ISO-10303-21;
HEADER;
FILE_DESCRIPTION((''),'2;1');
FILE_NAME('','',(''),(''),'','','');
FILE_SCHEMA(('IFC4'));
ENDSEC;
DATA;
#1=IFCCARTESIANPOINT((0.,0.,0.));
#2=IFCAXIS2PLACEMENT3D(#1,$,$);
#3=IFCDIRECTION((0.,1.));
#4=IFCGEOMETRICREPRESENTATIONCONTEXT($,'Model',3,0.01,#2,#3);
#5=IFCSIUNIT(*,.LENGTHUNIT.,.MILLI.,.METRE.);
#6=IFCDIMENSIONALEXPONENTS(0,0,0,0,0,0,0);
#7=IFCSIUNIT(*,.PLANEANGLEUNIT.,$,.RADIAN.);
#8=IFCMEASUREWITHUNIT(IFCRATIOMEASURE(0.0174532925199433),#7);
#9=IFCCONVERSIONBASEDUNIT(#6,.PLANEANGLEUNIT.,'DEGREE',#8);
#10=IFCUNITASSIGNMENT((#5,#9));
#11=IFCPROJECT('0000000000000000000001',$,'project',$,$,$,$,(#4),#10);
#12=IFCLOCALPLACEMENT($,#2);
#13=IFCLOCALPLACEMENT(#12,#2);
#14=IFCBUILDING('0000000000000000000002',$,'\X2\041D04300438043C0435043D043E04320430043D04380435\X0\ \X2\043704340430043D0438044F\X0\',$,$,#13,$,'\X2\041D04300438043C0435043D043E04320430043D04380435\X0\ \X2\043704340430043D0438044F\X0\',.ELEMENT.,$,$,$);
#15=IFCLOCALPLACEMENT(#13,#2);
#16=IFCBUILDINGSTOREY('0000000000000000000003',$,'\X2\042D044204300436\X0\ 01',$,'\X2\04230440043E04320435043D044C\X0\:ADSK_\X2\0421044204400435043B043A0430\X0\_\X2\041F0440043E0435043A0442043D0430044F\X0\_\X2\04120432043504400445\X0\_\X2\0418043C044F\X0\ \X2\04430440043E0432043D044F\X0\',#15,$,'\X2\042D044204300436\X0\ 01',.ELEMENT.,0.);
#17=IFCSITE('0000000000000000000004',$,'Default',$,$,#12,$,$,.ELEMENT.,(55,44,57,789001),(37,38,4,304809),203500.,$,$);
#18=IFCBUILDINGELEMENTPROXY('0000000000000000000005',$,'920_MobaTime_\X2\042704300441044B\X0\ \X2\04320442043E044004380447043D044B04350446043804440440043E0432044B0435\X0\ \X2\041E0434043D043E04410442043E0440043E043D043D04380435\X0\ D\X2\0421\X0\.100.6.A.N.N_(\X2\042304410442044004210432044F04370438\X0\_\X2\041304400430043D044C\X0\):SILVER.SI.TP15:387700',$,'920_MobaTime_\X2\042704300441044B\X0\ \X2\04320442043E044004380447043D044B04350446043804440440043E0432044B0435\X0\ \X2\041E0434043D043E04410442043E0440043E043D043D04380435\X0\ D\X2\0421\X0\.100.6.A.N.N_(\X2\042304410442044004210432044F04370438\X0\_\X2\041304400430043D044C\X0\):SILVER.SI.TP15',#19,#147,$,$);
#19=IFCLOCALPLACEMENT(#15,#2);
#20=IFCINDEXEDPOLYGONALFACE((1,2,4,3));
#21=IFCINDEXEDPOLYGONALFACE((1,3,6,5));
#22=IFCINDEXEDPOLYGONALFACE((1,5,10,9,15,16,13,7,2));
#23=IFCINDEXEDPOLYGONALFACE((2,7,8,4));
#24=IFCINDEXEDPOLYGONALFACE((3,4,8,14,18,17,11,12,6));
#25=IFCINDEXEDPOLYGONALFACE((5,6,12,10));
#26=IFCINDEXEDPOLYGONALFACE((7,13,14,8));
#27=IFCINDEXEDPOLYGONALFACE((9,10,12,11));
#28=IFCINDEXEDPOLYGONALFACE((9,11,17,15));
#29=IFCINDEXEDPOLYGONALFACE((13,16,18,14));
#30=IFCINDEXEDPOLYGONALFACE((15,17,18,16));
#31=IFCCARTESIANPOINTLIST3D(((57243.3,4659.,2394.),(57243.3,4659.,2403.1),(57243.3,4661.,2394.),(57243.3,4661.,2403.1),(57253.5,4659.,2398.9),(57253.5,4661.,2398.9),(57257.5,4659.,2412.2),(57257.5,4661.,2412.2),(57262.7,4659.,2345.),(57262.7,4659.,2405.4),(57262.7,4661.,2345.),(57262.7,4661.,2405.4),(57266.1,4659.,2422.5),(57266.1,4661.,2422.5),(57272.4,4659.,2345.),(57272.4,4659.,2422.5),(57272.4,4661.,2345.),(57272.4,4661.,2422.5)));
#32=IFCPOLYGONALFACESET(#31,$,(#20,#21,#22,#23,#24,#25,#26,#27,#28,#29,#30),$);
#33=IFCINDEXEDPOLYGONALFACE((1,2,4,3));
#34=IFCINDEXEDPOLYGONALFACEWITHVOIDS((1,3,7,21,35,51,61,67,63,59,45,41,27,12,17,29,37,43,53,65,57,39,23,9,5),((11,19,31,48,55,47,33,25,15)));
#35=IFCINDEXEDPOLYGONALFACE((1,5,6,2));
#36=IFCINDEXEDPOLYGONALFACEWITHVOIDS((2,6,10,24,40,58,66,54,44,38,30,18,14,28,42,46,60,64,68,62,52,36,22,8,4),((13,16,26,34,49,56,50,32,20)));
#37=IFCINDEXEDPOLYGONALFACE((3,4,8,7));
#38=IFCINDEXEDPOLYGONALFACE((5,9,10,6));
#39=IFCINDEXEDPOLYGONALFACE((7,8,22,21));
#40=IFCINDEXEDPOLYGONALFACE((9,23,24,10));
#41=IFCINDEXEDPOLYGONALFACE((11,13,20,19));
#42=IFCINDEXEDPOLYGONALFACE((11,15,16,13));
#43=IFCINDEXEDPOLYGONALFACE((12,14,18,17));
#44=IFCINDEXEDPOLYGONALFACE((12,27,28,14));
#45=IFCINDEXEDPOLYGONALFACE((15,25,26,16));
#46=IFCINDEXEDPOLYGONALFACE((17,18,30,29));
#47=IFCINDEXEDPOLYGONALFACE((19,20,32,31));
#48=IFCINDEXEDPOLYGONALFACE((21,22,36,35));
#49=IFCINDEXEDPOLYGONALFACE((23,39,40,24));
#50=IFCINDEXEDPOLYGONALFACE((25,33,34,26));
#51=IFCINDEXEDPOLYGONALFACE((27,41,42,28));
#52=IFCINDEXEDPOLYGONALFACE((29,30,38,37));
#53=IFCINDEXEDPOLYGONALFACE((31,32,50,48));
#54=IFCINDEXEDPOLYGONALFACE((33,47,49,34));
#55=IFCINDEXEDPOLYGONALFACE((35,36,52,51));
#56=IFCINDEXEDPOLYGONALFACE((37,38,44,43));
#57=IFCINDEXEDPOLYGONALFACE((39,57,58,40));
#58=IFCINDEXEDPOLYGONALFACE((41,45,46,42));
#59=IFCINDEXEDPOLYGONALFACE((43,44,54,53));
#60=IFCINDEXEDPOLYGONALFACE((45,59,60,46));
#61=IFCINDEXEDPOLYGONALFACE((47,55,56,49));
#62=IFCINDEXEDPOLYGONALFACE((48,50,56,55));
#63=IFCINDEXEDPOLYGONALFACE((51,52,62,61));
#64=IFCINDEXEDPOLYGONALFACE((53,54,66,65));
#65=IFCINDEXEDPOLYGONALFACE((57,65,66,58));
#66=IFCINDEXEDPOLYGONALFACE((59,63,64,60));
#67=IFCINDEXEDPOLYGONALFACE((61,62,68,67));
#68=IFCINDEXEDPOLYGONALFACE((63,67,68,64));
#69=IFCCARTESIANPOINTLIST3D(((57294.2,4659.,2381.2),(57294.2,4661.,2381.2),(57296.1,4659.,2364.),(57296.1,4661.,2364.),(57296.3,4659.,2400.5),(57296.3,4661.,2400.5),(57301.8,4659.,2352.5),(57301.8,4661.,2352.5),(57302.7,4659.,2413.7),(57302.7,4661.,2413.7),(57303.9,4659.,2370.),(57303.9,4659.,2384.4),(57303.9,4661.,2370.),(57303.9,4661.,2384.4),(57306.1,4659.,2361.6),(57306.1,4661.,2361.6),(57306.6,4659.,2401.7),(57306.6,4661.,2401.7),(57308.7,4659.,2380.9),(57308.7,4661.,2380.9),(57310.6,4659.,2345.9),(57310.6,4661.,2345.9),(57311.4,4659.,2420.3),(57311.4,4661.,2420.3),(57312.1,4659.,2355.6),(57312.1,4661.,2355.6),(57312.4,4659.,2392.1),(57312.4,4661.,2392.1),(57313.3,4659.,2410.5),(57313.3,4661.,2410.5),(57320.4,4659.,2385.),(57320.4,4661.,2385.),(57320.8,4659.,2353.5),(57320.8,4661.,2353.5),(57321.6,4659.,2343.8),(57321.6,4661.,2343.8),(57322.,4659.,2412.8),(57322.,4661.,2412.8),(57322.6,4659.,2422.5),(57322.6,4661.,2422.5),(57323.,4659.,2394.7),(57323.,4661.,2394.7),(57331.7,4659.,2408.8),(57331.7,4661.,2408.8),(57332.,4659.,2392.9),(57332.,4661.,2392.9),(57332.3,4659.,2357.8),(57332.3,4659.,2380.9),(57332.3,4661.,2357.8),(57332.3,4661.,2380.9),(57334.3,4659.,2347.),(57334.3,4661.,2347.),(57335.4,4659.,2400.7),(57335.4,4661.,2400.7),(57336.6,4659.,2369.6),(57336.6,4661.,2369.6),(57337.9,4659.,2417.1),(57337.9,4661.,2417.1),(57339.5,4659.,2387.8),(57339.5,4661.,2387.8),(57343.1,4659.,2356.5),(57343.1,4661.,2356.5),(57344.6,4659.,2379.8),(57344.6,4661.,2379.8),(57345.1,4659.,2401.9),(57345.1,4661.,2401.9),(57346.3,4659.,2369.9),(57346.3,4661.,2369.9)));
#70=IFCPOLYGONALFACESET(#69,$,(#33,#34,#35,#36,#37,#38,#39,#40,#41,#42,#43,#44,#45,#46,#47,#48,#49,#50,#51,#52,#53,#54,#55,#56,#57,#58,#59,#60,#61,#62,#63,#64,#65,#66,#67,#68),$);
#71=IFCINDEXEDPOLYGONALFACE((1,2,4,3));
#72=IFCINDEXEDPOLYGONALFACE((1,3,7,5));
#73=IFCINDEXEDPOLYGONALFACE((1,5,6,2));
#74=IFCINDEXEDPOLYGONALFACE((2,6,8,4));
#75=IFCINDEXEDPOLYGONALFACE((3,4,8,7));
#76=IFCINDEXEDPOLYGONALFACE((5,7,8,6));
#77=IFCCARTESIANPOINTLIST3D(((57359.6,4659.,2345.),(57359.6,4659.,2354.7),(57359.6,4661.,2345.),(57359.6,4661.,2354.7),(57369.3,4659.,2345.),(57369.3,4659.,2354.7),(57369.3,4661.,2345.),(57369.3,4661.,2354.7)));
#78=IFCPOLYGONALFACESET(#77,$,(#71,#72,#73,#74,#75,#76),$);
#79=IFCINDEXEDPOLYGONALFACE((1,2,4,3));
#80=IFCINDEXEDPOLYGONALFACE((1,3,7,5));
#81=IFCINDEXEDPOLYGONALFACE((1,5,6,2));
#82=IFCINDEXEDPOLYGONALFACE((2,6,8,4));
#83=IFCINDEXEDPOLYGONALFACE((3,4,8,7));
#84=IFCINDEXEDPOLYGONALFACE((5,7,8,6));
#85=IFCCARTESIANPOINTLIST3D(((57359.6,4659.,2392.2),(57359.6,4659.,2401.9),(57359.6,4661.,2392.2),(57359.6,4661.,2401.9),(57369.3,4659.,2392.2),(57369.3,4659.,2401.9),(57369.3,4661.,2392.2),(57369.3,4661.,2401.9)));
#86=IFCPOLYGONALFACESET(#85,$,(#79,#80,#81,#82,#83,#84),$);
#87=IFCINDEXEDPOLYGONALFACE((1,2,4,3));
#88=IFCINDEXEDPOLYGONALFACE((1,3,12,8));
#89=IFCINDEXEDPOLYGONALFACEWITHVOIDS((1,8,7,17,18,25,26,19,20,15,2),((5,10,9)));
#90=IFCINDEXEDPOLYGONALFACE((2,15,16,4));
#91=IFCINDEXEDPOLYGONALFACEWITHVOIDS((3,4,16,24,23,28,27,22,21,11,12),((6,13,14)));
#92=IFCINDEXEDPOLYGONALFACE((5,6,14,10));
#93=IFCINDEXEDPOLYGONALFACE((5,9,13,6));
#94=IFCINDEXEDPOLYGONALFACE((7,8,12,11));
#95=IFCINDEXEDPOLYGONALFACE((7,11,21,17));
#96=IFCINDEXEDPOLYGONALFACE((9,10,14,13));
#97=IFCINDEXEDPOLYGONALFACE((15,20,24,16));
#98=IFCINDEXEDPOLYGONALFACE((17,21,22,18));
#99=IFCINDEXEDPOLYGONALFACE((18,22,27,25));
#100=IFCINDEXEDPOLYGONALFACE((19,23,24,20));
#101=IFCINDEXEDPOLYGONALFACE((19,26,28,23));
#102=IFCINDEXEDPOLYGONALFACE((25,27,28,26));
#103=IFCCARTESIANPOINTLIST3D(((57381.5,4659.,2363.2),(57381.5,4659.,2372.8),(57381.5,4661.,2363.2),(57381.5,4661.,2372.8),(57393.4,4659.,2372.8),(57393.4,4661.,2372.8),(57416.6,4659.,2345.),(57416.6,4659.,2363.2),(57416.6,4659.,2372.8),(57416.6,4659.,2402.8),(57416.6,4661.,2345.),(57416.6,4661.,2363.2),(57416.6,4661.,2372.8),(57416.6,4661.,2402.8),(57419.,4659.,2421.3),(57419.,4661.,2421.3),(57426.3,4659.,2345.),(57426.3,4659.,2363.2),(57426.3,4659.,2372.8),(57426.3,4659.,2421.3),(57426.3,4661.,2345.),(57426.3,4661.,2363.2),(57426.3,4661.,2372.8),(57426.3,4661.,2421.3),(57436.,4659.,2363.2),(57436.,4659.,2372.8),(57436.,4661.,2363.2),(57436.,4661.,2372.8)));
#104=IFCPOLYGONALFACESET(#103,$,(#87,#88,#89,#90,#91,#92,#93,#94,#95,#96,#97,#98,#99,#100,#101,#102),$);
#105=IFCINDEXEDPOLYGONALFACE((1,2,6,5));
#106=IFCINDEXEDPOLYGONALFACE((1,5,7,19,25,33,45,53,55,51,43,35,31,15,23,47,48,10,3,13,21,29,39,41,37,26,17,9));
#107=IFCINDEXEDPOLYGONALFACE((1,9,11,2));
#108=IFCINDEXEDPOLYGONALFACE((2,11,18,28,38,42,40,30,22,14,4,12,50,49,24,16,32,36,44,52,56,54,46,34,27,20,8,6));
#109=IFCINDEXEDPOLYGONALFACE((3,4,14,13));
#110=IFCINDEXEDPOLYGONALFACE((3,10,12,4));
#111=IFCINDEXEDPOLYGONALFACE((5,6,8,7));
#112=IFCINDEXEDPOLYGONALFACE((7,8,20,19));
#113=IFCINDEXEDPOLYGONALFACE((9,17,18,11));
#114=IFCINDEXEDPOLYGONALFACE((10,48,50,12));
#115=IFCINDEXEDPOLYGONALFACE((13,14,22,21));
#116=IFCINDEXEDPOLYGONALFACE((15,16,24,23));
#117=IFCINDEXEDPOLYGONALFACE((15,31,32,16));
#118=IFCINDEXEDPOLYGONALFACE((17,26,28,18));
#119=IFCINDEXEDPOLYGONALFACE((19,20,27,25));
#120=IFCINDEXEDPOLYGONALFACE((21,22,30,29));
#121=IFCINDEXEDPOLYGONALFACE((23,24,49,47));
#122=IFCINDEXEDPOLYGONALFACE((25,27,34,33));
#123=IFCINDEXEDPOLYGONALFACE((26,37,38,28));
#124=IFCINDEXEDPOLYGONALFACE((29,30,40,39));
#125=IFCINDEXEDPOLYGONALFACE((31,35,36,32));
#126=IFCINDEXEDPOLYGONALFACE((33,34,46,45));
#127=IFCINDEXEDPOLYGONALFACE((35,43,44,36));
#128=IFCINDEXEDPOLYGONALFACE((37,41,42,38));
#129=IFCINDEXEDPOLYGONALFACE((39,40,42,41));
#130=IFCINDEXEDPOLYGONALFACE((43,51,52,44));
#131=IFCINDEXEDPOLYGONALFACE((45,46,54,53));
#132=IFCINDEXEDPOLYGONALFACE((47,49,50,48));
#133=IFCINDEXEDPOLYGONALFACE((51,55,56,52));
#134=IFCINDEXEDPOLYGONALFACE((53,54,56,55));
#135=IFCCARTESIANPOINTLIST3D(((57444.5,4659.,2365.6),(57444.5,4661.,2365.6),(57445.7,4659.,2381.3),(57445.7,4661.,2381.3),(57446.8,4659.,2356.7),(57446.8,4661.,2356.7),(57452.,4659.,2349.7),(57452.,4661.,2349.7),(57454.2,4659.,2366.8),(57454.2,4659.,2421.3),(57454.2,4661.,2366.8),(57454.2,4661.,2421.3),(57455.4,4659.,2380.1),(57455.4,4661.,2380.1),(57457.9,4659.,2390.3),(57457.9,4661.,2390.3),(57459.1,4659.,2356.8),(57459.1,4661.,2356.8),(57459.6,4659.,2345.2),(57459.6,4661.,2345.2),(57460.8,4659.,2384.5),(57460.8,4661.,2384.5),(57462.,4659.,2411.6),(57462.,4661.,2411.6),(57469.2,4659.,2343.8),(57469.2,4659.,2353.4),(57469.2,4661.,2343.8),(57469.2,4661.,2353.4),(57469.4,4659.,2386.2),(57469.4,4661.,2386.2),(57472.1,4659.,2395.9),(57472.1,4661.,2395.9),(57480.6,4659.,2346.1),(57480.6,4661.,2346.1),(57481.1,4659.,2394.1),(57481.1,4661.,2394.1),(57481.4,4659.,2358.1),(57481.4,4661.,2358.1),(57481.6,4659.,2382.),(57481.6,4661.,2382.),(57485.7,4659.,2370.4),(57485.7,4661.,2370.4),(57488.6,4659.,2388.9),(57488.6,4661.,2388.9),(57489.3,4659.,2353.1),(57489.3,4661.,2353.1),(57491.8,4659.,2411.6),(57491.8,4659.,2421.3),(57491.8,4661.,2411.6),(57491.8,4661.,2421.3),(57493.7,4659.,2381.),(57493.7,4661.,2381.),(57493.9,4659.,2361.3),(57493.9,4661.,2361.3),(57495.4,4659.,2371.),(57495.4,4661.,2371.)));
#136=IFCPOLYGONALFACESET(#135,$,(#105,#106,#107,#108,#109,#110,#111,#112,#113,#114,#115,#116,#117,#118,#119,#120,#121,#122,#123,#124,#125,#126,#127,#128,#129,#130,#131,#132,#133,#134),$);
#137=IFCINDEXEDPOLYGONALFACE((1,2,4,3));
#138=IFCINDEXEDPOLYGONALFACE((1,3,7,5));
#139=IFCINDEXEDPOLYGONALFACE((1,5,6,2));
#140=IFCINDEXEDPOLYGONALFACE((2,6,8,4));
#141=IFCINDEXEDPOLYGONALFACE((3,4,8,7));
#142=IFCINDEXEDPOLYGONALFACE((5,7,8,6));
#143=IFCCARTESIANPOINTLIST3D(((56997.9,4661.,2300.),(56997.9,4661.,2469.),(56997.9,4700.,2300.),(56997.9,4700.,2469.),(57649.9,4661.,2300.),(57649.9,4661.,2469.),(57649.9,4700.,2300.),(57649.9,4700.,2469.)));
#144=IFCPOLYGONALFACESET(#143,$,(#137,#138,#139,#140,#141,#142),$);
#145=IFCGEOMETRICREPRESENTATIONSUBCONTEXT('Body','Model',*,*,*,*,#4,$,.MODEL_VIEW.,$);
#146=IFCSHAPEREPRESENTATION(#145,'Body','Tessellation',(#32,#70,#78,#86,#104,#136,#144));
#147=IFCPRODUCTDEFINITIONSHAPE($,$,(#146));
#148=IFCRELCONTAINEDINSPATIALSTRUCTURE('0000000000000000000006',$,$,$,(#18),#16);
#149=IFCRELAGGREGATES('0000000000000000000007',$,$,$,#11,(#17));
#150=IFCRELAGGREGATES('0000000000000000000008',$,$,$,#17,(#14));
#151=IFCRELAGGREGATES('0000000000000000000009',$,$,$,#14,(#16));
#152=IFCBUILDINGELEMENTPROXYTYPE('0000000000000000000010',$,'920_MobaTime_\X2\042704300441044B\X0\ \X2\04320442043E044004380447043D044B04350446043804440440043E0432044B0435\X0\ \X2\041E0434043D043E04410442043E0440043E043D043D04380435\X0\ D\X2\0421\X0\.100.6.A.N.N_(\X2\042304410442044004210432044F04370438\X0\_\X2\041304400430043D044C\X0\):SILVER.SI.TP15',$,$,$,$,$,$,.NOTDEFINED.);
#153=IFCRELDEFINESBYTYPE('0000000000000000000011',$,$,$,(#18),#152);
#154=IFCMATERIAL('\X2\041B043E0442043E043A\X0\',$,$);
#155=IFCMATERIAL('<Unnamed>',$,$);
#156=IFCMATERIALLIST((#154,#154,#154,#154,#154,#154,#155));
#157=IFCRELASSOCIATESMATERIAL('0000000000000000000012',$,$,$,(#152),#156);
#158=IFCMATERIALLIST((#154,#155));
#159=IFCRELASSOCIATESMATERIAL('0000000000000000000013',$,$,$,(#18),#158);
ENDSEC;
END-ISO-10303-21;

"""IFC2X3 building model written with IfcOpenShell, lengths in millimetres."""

from ifc_helpers import new_model, entity, si_unit, converted_unit, direction, frame, origin, origin_2d_with_axis, place, context, subcontext, project, spatial, polyline, rectangle, outline, extrude, source, transform, mapped, material, material_list, type_object, type_shapes, element, save


model = new_model("IFC2X3")

# Units and contexts
model_context = context("Model", 3, precision=0.01, world=origin(), true_north=direction((0.0, 1.0)))
body_context = subcontext(model_context, "Body", "Model", "MODEL_VIEW")
ifc_project = project(units=[si_unit("LENGTHUNIT", "METRE", prefix="MILLI"), converted_unit("PLANEANGLEUNIT", "DEGREE", entity("IfcRatioMeasure", 0.0174532925199433), si_unit("PLANEANGLEUNIT", "RADIAN"), dimensions=[0, 0, 0, 0, 0, 0, 0])], contexts=[model_context])

# Site, building, storey
site_placement = place(None, origin())
site = spatial("IfcSite", under=ifc_project, at=site_placement, Name="Default", CompositionType="ELEMENT", RefLatitude=(55, 44, 57, 789001), RefLongitude=(37, 38, 4, 304809), RefElevation=203500.0)
building_placement = place(site_placement, origin())
building = spatial("IfcBuilding", under=site, at=building_placement, Name="Наименование здания", LongName="Наименование здания", CompositionType="ELEMENT")
storey_placement = place(building_placement, origin())
storey = spatial("IfcBuildingStorey", under=building, at=storey_placement, Name="Этаж 01", ObjectType="Уровень:ADSK_Стрелка_Проектная_Вверх_Имя уровня", LongName="Этаж 01", CompositionType="ELEMENT", Elevation=0.0)

# Building element proxy
ifc_material_1 = material(Name="Лоток")
ifc_material_2 = material(Name="<Unnamed>")
ifc_material_list_1 = material_list([ifc_material_1, ifc_material_1, ifc_material_1, ifc_material_1, ifc_material_1, ifc_material_1, ifc_material_2])
building_element_proxy_type = type_object("IfcBuildingElementProxyType", Name="920_MobaTime_Часы вторичныецифровые Односторонние DС.100.6.A.N.N_(УстрСвязи_Грань):SILVER.SI.TP15", PredefinedType="NOTDEFINED", material=ifc_material_list_1)
shared_shape = source(origin(), body_context, "Body", "SweptSolid", [
    extrude(outline(polyline([(-49.3, -13.1), (28.2, -13.1), (28.2, -6.8), (17.9, 1.8), (8.8, 16.0), (-0.3, 16.0), (4.6, 5.8), (11.1, -3.4), (-49.3, -3.4), (-49.3, -13.1)])), frame((-64.6, 9.8, 39.0), z_axis=(0.0, 0.0, 1.0), x_axis=(0.0, 1.0, 0.0)), (0.0, 0.0, 1.0), 2.0),
    extrude(outline(polyline([(2.2, -27.6), (19.0, -27.6), (30.5, -16.1), (33.3, -4.9), (31.0, 5.8), (21.8, 17.2), (5.2, 27.3), (-11.1, 33.0), (-24.0, 32.7), (-33.6, 27.6), (-40.3, 18.6), (-42.8, 5.7), (-38.0, -6.3), (-27.2, -14.9), (-17.5, -17.7), (-8.2, -16.4), (-0.3, -11.9), (5.1, -4.5), (7.3, 6.2), (4.0, 17.2), (18.4, 7.3), (23.6, -2.4), (22.0, -11.4), (14.2, -18.4), (5.3, -18.3), (2.2, -27.6)]), holes=[polyline([(-9.0, 23.3), (-1.3, 14.3), (-2.5, 2.0), (-11.4, -7.0), (-23.4, -6.0), (-32.2, 2.9), (-31.2, 15.1), (-25.6, 22.1), (-17.5, 24.9), (-9.0, 23.3)])]), frame((-2.7, 3.6, 39.0), z_axis=(0.0, 0.0, 1.0), x_axis=(-0.427649, 0.903945, 0.0)), (0.0, 0.0, 1.0), 2.0),
    extrude(rectangle(XDim=9.7, YDim=9.7, at=origin_2d_with_axis()), frame((40.6, -34.7, 39.0)), (0.0, 0.0, 1.0), 2.0),
    extrude(rectangle(XDim=9.7, YDim=9.7, at=origin_2d_with_axis()), frame((40.6, 12.6, 39.0)), (0.0, 0.0, 1.0), 2.0),
    extrude(outline(polyline([(-0.9, -28.1), (8.8, -28.1), (8.8, -9.9), (18.5, -9.9), (18.5, -0.2), (8.8, -0.2), (8.8, 48.3), (1.5, 48.3), (-36.0, -0.2), (-36.0, -9.9), (-0.9, -9.9), (-0.9, -28.1)]), holes=[polyline([(-0.9, -0.2), (-24.1, -0.2), (-0.9, 29.7), (-0.9, -0.2)])]), frame((93.6, -11.4, 39.0)), (0.0, 0.0, 1.0), 2.0),
    extrude(outline(polyline([(3.3, -28.3), (12.5, -28.3), (20.5, -25.0), (26.8, -18.9), (30.7, -10.0), (31.4, 1.6), (26.9, 11.8), (20.1, 18.4), (11.1, 22.3), (1.0, 23.3), (-7.9, 20.4), (-14.9, 14.5), (-18.9, 6.2), (-17.1, -9.0), (-36.7, 0.5), (-29.1, 29.2), (-38.5, 31.7), (-48.1, -4.6), (-11.6, -23.1), (-8.0, -14.0), (-10.8, -7.6), (-10.2, 1.1), (-3.0, 11.8), (9.2, 12.8), (20.0, 5.5), (21.4, -7.5), (15.5, -16.4), (4.6, -18.6), (3.3, -28.3)])), frame((147.1, -8.5, 39.0), z_axis=(0.0, 0.0, 1.0), x_axis=(0.256974, -0.966418, 0.0)), (0.0, 0.0, 1.0), 2.0),
    extrude(rectangle(XDim=652.0, YDim=169.0, at=origin_2d_with_axis()), frame((0.0, 0.0, 0.0), z_axis=(0.0, 0.0, 1.0), x_axis=(-1.0, 0.0, 0.0)), (0.0, 0.0, 1.0), 39.0),
])
type_shapes(building_element_proxy_type, [shared_shape])
ifc_material_list_2 = material_list([ifc_material_1, ifc_material_2])
for number, where, z_axis, x_axis, name in (
    (1, (57323.9, 4700.0, 2384.5), (0.0, -1.0, 0.0), (1.0, 0.0, 0.0), "920_MobaTime_Часы вторичныецифровые Односторонние DС.100.6.A.N.N_(УстрСвязи_Грань):SILVER.SI.TP15:387700"),
):
    element("IfcBuildingElementProxy", number, at=place(storey_placement, frame(where, z_axis=z_axis, x_axis=x_axis)), inside=storey, type_object=building_element_proxy_type, material=ifc_material_list_2, Name=name, ObjectType="920_MobaTime_Часы вторичныецифровые Односторонние DС.100.6.A.N.N_(УстрСвязи_Грань):SILVER.SI.TP15", context=body_context, shape_type="MappedRepresentation", body=[
        mapped(shared_shape, transform((0.0, 0.0, 0.0), scale=1.0)),
    ])

save(model, "model.ifc")
